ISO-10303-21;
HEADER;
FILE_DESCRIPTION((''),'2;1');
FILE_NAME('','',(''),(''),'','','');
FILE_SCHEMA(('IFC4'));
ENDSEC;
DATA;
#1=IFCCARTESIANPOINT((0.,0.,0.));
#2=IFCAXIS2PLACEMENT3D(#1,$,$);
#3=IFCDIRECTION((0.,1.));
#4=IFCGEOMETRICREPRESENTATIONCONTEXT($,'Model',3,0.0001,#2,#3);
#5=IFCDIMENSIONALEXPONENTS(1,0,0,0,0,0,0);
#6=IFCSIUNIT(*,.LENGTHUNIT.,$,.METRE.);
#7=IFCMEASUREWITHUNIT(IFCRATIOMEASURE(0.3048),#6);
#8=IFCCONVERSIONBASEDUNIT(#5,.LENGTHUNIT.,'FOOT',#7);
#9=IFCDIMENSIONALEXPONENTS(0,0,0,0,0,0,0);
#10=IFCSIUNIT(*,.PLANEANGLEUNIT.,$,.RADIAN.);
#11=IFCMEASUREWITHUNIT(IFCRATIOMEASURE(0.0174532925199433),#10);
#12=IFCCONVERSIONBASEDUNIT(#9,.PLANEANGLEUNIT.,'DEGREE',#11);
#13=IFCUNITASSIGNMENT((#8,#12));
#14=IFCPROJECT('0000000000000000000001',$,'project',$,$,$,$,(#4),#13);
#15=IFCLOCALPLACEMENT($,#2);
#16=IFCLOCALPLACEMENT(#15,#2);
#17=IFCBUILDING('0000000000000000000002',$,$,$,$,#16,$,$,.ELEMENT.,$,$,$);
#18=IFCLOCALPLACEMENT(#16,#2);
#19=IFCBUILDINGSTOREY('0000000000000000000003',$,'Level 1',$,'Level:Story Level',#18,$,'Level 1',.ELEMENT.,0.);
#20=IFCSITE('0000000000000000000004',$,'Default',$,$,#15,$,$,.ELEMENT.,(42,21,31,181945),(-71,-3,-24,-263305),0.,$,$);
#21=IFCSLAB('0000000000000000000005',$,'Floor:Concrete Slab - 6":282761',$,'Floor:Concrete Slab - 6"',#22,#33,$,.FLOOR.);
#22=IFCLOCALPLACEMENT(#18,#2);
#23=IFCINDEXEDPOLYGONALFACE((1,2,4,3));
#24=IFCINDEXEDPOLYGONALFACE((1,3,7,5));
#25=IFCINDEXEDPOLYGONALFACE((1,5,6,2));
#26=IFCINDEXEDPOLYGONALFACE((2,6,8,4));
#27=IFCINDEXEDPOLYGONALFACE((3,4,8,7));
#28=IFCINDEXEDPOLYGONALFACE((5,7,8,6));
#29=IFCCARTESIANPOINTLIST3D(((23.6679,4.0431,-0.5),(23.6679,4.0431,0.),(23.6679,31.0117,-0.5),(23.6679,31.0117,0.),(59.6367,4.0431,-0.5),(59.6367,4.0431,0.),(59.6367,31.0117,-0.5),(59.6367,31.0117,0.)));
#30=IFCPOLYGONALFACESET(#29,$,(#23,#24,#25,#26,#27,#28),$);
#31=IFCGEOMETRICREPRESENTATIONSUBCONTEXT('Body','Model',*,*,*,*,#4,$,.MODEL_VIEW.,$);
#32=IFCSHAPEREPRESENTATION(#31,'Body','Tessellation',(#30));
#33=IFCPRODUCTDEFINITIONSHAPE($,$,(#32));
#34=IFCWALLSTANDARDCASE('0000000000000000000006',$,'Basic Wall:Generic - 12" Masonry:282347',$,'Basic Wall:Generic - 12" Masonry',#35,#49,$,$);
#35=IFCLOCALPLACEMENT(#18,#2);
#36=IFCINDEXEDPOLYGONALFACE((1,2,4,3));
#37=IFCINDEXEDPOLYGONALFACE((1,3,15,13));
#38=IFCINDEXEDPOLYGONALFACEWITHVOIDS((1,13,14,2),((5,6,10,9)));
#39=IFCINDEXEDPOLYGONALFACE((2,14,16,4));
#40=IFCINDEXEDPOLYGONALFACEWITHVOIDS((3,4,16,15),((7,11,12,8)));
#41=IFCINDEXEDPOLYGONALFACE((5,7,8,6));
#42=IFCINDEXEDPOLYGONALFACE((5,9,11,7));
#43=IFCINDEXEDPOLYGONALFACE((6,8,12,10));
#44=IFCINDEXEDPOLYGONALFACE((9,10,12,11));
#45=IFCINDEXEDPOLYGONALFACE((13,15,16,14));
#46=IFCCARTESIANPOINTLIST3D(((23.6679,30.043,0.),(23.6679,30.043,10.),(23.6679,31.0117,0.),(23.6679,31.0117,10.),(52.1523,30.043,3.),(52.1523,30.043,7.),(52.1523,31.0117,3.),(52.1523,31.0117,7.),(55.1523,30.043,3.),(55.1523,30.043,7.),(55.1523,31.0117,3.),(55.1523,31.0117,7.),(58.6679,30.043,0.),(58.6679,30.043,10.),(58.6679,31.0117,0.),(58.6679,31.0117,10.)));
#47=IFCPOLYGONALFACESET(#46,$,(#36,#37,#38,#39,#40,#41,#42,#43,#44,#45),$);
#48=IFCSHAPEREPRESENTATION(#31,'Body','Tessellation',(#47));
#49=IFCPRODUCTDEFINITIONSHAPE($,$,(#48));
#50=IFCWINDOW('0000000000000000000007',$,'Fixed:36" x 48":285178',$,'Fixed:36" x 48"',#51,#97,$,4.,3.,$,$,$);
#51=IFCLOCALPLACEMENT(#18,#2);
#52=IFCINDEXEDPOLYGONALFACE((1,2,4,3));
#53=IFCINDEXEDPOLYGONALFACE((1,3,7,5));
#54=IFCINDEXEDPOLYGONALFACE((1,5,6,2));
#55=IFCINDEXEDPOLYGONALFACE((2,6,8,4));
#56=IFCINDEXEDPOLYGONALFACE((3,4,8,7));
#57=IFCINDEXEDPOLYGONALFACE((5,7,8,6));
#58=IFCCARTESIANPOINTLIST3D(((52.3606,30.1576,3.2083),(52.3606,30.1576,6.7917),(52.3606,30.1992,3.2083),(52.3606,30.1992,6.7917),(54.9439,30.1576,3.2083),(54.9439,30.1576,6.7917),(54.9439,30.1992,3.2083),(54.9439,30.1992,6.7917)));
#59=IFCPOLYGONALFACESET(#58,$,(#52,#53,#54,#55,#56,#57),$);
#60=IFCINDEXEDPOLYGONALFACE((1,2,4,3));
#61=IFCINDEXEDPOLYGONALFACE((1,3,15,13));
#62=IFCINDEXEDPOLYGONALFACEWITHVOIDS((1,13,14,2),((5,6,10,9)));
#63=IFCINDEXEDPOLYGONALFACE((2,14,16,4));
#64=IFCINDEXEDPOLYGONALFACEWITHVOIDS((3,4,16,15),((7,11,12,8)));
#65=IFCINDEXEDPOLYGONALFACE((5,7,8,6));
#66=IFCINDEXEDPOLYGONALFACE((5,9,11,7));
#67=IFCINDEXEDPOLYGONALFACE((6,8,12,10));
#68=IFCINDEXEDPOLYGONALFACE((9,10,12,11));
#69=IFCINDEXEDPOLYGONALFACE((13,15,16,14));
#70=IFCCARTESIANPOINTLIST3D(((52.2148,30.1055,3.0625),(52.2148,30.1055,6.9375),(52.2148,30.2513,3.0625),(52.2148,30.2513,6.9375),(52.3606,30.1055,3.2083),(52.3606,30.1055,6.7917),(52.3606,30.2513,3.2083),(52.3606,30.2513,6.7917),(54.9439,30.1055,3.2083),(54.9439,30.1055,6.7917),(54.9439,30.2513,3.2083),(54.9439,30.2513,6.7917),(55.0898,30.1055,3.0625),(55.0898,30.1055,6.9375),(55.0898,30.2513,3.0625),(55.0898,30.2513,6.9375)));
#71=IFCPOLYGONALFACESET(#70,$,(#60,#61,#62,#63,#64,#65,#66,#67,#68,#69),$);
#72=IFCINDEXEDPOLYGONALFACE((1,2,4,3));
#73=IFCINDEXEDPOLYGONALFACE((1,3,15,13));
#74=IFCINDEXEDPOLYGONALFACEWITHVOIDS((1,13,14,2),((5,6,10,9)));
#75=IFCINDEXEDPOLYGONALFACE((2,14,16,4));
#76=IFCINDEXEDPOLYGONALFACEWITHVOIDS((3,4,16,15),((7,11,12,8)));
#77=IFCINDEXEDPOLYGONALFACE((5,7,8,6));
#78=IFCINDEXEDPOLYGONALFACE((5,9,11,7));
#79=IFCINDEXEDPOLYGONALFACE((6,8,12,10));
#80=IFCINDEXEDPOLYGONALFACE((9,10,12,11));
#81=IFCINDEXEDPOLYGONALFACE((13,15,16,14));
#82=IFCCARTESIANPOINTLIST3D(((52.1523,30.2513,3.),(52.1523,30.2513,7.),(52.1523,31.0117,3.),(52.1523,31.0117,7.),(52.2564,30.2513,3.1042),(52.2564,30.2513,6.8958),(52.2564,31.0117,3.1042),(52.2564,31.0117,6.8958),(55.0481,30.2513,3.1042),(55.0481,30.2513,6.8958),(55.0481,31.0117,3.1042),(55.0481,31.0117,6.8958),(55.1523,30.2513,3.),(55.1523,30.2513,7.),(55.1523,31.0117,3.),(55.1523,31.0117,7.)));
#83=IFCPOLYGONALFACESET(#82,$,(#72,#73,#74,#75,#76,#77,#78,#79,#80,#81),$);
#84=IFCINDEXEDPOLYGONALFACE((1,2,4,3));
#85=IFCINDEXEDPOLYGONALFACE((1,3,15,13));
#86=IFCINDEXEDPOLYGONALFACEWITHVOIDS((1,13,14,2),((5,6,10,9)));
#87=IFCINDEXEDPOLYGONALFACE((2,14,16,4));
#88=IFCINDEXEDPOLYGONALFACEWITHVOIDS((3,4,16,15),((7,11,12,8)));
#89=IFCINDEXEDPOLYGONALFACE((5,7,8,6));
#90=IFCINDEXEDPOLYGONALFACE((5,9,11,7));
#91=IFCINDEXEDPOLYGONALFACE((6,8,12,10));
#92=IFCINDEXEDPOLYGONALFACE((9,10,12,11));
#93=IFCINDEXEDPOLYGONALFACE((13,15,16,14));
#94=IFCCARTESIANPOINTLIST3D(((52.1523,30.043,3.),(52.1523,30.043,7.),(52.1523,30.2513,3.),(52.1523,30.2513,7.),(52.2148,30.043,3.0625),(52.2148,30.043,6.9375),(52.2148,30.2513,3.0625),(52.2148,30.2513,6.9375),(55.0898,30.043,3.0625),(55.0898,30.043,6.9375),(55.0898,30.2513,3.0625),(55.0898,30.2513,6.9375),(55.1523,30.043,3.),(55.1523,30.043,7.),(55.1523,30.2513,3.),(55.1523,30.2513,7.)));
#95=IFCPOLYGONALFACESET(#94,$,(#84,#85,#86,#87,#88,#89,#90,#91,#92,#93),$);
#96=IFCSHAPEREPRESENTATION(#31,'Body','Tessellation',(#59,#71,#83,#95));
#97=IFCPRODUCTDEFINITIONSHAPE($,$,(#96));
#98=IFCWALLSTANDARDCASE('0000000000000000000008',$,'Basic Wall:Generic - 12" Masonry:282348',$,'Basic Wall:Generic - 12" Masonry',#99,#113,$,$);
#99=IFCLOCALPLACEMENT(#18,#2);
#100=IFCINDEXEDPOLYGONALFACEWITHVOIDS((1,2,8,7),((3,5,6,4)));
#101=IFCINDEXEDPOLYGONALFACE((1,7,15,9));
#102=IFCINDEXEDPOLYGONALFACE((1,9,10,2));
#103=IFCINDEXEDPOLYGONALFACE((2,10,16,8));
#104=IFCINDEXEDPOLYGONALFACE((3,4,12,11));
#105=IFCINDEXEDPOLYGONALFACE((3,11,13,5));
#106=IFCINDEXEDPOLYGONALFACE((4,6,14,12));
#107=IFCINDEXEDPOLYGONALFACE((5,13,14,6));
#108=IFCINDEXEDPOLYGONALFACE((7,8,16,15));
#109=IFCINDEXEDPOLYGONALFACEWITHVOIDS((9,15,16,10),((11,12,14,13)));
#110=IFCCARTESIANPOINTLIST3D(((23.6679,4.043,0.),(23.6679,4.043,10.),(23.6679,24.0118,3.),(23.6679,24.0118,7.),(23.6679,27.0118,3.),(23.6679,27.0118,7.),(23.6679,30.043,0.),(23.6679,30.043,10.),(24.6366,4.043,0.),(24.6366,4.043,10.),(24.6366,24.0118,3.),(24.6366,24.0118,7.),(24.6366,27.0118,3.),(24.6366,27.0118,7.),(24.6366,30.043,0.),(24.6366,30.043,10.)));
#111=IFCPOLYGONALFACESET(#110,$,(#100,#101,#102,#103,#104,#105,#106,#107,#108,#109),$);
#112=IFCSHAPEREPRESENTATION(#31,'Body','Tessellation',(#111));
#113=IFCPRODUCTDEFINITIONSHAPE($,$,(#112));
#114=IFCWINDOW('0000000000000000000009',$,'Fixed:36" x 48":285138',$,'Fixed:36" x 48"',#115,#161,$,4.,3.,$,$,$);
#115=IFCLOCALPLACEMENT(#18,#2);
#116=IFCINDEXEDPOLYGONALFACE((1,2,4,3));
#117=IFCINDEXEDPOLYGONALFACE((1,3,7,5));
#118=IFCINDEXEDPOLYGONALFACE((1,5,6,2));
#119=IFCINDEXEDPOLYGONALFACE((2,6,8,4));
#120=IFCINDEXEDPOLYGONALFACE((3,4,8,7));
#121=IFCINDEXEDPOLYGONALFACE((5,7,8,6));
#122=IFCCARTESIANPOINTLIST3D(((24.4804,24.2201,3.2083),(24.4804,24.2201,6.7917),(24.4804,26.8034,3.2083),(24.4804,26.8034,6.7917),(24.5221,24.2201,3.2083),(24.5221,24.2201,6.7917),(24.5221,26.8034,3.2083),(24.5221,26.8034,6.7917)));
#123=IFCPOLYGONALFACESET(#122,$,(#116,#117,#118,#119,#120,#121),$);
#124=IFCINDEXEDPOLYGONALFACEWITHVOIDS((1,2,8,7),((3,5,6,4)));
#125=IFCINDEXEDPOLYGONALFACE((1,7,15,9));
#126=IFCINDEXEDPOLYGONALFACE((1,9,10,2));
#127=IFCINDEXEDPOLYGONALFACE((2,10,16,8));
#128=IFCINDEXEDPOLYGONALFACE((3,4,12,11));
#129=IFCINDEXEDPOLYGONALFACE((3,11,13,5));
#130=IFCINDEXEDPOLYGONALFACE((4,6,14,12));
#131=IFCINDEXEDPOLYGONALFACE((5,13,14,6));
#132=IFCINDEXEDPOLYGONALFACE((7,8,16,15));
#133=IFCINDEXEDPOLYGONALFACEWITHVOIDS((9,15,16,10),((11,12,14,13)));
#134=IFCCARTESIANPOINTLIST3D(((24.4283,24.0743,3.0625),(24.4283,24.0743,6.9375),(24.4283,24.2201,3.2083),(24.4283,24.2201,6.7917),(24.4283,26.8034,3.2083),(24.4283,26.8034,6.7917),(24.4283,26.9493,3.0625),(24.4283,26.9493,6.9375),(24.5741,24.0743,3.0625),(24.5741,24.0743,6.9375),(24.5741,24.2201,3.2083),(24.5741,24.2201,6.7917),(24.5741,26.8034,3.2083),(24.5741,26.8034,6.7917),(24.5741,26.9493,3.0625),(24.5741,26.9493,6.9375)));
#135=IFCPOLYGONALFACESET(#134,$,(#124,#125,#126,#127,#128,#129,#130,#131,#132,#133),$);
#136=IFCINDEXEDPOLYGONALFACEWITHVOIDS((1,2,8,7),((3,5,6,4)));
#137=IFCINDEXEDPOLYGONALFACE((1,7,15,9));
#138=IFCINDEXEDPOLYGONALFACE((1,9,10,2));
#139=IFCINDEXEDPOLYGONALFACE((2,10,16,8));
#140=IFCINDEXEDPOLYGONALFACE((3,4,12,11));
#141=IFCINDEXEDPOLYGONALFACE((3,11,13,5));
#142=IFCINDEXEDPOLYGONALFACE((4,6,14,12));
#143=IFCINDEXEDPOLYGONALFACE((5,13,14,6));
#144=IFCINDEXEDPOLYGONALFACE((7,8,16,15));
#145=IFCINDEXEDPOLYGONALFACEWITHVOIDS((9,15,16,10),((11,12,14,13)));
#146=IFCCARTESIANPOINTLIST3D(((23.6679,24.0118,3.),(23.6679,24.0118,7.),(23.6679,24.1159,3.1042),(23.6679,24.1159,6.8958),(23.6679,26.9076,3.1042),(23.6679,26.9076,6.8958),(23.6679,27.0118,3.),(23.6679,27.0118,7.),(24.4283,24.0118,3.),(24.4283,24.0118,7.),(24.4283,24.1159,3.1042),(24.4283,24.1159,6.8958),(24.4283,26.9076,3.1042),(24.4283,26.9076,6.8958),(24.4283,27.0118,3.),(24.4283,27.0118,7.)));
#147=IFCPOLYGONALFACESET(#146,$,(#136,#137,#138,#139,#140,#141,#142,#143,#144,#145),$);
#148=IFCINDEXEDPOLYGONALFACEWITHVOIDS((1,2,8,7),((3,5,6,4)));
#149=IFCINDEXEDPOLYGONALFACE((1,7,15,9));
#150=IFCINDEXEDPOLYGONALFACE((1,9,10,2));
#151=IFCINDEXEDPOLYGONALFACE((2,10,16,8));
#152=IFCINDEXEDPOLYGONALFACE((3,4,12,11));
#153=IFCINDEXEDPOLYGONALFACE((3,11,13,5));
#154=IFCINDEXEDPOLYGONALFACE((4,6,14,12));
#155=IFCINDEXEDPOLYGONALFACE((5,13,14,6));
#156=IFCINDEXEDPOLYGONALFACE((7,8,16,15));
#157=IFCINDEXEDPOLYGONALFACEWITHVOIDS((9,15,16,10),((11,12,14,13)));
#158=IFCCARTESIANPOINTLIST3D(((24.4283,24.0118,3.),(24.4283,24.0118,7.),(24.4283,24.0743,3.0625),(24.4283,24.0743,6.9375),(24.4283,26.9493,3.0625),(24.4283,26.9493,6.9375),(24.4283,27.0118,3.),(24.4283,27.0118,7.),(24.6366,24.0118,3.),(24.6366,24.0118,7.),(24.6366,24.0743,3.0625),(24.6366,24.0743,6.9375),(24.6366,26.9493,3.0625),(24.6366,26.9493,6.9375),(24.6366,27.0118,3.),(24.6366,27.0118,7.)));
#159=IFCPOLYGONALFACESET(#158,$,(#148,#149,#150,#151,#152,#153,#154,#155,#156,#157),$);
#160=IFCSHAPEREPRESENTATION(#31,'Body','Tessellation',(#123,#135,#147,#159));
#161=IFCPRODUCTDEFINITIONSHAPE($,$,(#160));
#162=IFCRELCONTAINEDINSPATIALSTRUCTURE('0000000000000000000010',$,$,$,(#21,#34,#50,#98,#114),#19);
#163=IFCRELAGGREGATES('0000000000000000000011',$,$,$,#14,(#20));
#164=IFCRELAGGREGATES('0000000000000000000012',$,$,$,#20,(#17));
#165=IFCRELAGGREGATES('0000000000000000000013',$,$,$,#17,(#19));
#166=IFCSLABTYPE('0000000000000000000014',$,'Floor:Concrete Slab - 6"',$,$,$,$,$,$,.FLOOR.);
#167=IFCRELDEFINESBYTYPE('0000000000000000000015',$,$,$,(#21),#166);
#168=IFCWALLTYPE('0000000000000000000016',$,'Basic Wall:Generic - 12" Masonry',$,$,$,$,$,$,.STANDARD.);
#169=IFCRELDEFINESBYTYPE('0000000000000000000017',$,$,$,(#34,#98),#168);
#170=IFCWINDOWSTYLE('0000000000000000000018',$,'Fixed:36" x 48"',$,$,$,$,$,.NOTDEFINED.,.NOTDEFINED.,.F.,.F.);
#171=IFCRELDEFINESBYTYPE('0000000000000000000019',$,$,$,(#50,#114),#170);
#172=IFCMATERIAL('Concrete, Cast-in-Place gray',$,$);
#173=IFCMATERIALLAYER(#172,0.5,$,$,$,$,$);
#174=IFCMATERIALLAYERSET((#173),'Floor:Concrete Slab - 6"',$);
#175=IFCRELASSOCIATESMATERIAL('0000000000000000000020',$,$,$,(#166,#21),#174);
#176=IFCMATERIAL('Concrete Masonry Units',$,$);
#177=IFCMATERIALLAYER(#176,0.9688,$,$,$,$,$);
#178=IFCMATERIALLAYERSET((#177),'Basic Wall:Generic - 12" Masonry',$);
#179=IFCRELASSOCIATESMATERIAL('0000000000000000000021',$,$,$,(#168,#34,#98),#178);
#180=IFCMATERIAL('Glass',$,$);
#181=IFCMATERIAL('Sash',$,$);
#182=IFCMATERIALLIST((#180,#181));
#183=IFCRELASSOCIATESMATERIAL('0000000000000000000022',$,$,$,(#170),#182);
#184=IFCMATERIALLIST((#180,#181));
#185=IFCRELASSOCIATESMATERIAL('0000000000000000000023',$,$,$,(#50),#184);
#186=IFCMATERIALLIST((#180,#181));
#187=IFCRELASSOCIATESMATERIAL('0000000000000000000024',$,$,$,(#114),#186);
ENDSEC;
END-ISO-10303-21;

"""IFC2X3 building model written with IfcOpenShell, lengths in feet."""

from ifc_helpers import new_model, entity, si_unit, converted_unit, direction, frame, frame_2d, origin, place, context, subcontext, project, spatial, polyline, rectangle, outline, extrude, source, transform, mapped, material, material_list, layer, layer_set, layer_usage, type_object, type_shapes, element, fill, save


model = new_model("IFC2X3")

# Units and contexts
model_context = context("Model", 3, precision=0.0001, world=origin(), true_north=direction((0.0, 1.0)))
body_context = subcontext(model_context, "Body", "Model", "MODEL_VIEW")
ifc_project = project(units=[converted_unit("LENGTHUNIT", "FOOT", entity("IfcRatioMeasure", 0.3048), si_unit("LENGTHUNIT", "METRE"), dimensions=[1, 0, 0, 0, 0, 0, 0]), converted_unit("PLANEANGLEUNIT", "DEGREE", entity("IfcRatioMeasure", 0.0174532925199433), si_unit("PLANEANGLEUNIT", "RADIAN"), dimensions=[0, 0, 0, 0, 0, 0, 0])], contexts=[model_context])

# Site, building, storey
site_placement = place(None, origin())
site = spatial("IfcSite", under=ifc_project, at=site_placement, Name="Default", CompositionType="ELEMENT", RefLatitude=(42, 21, 31, 181945), RefLongitude=(-71, -3, -24, -263305), RefElevation=0.0)
building_placement = place(site_placement, origin())
building = spatial("IfcBuilding", under=site, at=building_placement, CompositionType="ELEMENT")
storey_placement = place(building_placement, origin())
storey = spatial("IfcBuildingStorey", under=building, at=storey_placement, Name="Level 1", ObjectType="Level:Story Level", LongName="Level 1", CompositionType="ELEMENT", Elevation=0.0)

# Slab
ifc_material_1 = material(Name="Concrete, Cast-in-Place gray")
ifc_layer_1 = layer(ifc_material_1, 0.5)
ifc_layer_set_1 = layer_set([ifc_layer_1], Name="Floor:Concrete Slab - 6\"")
ifc_layer_usage_1 = layer_usage(ifc_layer_set_1, "AXIS3", "POSITIVE", 0.0)
slab_type = type_object("IfcSlabType", Name="Floor:Concrete Slab - 6\"", PredefinedType="FLOOR", material=ifc_layer_set_1)
slab_placement = place(storey_placement, origin())
element("IfcSlab", 1, at=slab_placement, inside=storey, type_object=slab_type, material=ifc_layer_usage_1, Name="Floor:Concrete Slab - 6\":282761", ObjectType="Floor:Concrete Slab - 6\"", PredefinedType="FLOOR", context=body_context, shape_type="SweptSolid", body=[
    extrude(rectangle(XDim=26.9687, YDim=35.9688, at=frame_2d((0.0, 0.0), x_axis=(1.0, 0.0))), frame((41.6523, 17.5274, 0.0), z_axis=(0.0, 0.0, -1.0), x_axis=(0.0, 1.0, 0.0)), (0.0, 0.0, 1.0), 0.5),
])

# Walls, openings, windows
ifc_material_2 = material(Name="Concrete Masonry Units")
ifc_layer_2 = layer(ifc_material_2, 0.9688)
ifc_layer_set_2 = layer_set([ifc_layer_2], Name="Basic Wall:Generic - 12\" Masonry")
ifc_layer_usage_2 = layer_usage(ifc_layer_set_2, "AXIS2", "NEGATIVE", 0.4844)
wall_type = type_object("IfcWallType", Name="Basic Wall:Generic - 12\" Masonry", PredefinedType="STANDARD", material=ifc_layer_set_2)
wall_1_placement = place(storey_placement, frame((23.6679, 30.5274, 0.0)))
wall_1 = element("IfcWallStandardCase", 2, at=wall_1_placement, inside=storey, type_object=wall_type, material=ifc_layer_usage_2, Name="Basic Wall:Generic - 12\" Masonry:282347", ObjectType="Basic Wall:Generic - 12\" Masonry", context=body_context, shape_type="SweptSolid", body=[
    extrude(rectangle(XDim=35.0, YDim=0.9688, at=frame_2d((17.5, 0.0), x_axis=(-1.0, 0.0))), origin(), (0.0, 0.0, 1.0), 10.0),
])
opening_1_placement = place(wall_1_placement, frame((31.4844, 0.4844, 3.0)))
opening_1 = element("IfcOpeningElement", 3, at=opening_1_placement, cuts=wall_1, ObjectType="Opening", context=body_context, shape_type="SweptSolid", body=[
    extrude(rectangle(XDim=4.0, YDim=3.0, at=frame_2d((2.0, 1.5), x_axis=(-1.0, 0.0))), frame((0.0, 0.0, 0.0), z_axis=(0.0, -1.0, 0.0), x_axis=(0.0, 0.0, 1.0)), (0.0, 0.0, 1.0), 0.9688),
])
ifc_material_3 = material(Name="Glass")
ifc_material_4 = material(Name="Sash")
ifc_material_list_1 = material_list([ifc_material_3, ifc_material_4])
ifc_material_list_2 = material_list([ifc_material_3, ifc_material_4])
window_style = type_object("IfcWindowStyle", Name="Fixed:36\" x 48\"", ConstructionType="NOTDEFINED", OperationType="NOTDEFINED", ParameterTakesPrecedence=False, Sizeable=False, material=ifc_material_list_2)
shared_shape_1 = source(origin(), body_context, "Body", "SweptSolid", [
    extrude(rectangle(XDim=0.0417, YDim=2.5833, at=frame_2d((0.0, 0.0), x_axis=(1.0, 0.0))), frame((1.5, 0.8333, 0.2083), z_axis=(0.0, 0.0, 1.0), x_axis=(0.0, 1.0, 0.0)), (0.0, 0.0, 1.0), 3.5833),
    extrude(outline(polyline([(-1.4375, -1.9375), (1.4375, -1.9375), (1.4375, 1.9375), (-1.4375, 1.9375), (-1.4375, -1.9375)]), holes=[polyline([(-1.2917, -1.7917), (-1.2917, 1.7917), (1.2917, 1.7917), (1.2917, -1.7917), (-1.2917, -1.7917)])]), frame((1.5, 0.7604, 2.0), z_axis=(0.0, 1.0, 0.0), x_axis=(1.0, 0.0, 0.0)), (0.0, 0.0, 1.0), 0.1458),
    extrude(outline(polyline([(-1.5, -2.0), (1.5, -2.0), (1.5, 2.0), (-1.5, 2.0), (-1.5, -2.0)]), holes=[polyline([(-1.3958, -1.8958), (-1.3958, 1.8958), (1.3958, 1.8958), (1.3958, -1.8958), (-1.3958, -1.8958)])]), frame((1.5, 0.0, 2.0), z_axis=(0.0, 1.0, 0.0), x_axis=(1.0, 0.0, 0.0)), (0.0, 0.0, 1.0), 0.7604),
    extrude(outline(polyline([(-2.0, -1.5), (2.0, -1.5), (2.0, 1.5), (-2.0, 1.5), (-2.0, -1.5)]), holes=[polyline([(-1.9375, -1.4375), (-1.9375, 1.4375), (1.9375, 1.4375), (1.9375, -1.4375), (-1.9375, -1.4375)])]), frame((1.5, 0.7604, 2.0), z_axis=(0.0, 1.0, 0.0), x_axis=(0.0, 0.0, -1.0)), (0.0, 0.0, 1.0), 0.2083),
])
type_shapes(window_style, [shared_shape_1])
window_1_placement = place(opening_1_placement, frame((0.0, 0.0, 0.0), z_axis=(0.0, 0.0, 1.0), x_axis=(-1.0, 0.0, 0.0)))
window_1 = element("IfcWindow", 4, at=window_1_placement, inside=storey, type_object=window_style, material=ifc_material_list_1, Name="Fixed:36\" x 48\":285178", ObjectType="Fixed:36\" x 48\"", OverallHeight=4.0, OverallWidth=3.0, context=body_context, shape_type="MappedRepresentation", body=[
    mapped(shared_shape_1, transform((0.0, 0.0, 0.0), scale=1.0)),
])
fill(opening_1, window_1)
ifc_layer_usage_3 = layer_usage(ifc_layer_set_2, "AXIS2", "NEGATIVE", 0.4844)
wall_2_placement = place(storey_placement, frame((24.1523, 4.043, 0.0), z_axis=(0.0, 0.0, 1.0), x_axis=(0.0, 1.0, 0.0)))
wall_2 = element("IfcWallStandardCase", 5, at=wall_2_placement, inside=storey, type_object=wall_type, material=ifc_layer_usage_3, Name="Basic Wall:Generic - 12\" Masonry:282348", ObjectType="Basic Wall:Generic - 12\" Masonry", context=body_context, shape_type="SweptSolid", body=[
    extrude(rectangle(XDim=26.0, YDim=0.9688, at=frame_2d((13.0, 0.0), x_axis=(-1.0, 0.0))), origin(), (0.0, 0.0, 1.0), 10.0),
])
opening_2_placement = place(wall_2_placement, frame((22.9688, 0.4844, 3.0)))
opening_2 = element("IfcOpeningElement", 6, at=opening_2_placement, cuts=wall_2, ObjectType="Opening", context=body_context, shape_type="SweptSolid", body=[
    extrude(rectangle(XDim=4.0, YDim=3.0, at=frame_2d((2.0, 1.5), x_axis=(-1.0, 0.0))), frame((0.0, 0.0, 0.0), z_axis=(0.0, -1.0, 0.0), x_axis=(0.0, 0.0, 1.0)), (0.0, 0.0, 1.0), 0.9688),
])
ifc_material_list_3 = material_list([ifc_material_3, ifc_material_4])
window_2_placement = place(opening_2_placement, frame((0.0, 0.0, 0.0), z_axis=(0.0, 0.0, 1.0), x_axis=(-1.0, 0.0, 0.0)))
window_2 = element("IfcWindow", 7, at=window_2_placement, inside=storey, type_object=window_style, material=ifc_material_list_3, Name="Fixed:36\" x 48\":285138", ObjectType="Fixed:36\" x 48\"", OverallHeight=4.0, OverallWidth=3.0, context=body_context, shape_type="MappedRepresentation", body=[
    mapped(shared_shape_1, transform((0.0, 0.0, 0.0), scale=1.0)),
])
fill(opening_2, window_2)

save(model, "model.ifc")
